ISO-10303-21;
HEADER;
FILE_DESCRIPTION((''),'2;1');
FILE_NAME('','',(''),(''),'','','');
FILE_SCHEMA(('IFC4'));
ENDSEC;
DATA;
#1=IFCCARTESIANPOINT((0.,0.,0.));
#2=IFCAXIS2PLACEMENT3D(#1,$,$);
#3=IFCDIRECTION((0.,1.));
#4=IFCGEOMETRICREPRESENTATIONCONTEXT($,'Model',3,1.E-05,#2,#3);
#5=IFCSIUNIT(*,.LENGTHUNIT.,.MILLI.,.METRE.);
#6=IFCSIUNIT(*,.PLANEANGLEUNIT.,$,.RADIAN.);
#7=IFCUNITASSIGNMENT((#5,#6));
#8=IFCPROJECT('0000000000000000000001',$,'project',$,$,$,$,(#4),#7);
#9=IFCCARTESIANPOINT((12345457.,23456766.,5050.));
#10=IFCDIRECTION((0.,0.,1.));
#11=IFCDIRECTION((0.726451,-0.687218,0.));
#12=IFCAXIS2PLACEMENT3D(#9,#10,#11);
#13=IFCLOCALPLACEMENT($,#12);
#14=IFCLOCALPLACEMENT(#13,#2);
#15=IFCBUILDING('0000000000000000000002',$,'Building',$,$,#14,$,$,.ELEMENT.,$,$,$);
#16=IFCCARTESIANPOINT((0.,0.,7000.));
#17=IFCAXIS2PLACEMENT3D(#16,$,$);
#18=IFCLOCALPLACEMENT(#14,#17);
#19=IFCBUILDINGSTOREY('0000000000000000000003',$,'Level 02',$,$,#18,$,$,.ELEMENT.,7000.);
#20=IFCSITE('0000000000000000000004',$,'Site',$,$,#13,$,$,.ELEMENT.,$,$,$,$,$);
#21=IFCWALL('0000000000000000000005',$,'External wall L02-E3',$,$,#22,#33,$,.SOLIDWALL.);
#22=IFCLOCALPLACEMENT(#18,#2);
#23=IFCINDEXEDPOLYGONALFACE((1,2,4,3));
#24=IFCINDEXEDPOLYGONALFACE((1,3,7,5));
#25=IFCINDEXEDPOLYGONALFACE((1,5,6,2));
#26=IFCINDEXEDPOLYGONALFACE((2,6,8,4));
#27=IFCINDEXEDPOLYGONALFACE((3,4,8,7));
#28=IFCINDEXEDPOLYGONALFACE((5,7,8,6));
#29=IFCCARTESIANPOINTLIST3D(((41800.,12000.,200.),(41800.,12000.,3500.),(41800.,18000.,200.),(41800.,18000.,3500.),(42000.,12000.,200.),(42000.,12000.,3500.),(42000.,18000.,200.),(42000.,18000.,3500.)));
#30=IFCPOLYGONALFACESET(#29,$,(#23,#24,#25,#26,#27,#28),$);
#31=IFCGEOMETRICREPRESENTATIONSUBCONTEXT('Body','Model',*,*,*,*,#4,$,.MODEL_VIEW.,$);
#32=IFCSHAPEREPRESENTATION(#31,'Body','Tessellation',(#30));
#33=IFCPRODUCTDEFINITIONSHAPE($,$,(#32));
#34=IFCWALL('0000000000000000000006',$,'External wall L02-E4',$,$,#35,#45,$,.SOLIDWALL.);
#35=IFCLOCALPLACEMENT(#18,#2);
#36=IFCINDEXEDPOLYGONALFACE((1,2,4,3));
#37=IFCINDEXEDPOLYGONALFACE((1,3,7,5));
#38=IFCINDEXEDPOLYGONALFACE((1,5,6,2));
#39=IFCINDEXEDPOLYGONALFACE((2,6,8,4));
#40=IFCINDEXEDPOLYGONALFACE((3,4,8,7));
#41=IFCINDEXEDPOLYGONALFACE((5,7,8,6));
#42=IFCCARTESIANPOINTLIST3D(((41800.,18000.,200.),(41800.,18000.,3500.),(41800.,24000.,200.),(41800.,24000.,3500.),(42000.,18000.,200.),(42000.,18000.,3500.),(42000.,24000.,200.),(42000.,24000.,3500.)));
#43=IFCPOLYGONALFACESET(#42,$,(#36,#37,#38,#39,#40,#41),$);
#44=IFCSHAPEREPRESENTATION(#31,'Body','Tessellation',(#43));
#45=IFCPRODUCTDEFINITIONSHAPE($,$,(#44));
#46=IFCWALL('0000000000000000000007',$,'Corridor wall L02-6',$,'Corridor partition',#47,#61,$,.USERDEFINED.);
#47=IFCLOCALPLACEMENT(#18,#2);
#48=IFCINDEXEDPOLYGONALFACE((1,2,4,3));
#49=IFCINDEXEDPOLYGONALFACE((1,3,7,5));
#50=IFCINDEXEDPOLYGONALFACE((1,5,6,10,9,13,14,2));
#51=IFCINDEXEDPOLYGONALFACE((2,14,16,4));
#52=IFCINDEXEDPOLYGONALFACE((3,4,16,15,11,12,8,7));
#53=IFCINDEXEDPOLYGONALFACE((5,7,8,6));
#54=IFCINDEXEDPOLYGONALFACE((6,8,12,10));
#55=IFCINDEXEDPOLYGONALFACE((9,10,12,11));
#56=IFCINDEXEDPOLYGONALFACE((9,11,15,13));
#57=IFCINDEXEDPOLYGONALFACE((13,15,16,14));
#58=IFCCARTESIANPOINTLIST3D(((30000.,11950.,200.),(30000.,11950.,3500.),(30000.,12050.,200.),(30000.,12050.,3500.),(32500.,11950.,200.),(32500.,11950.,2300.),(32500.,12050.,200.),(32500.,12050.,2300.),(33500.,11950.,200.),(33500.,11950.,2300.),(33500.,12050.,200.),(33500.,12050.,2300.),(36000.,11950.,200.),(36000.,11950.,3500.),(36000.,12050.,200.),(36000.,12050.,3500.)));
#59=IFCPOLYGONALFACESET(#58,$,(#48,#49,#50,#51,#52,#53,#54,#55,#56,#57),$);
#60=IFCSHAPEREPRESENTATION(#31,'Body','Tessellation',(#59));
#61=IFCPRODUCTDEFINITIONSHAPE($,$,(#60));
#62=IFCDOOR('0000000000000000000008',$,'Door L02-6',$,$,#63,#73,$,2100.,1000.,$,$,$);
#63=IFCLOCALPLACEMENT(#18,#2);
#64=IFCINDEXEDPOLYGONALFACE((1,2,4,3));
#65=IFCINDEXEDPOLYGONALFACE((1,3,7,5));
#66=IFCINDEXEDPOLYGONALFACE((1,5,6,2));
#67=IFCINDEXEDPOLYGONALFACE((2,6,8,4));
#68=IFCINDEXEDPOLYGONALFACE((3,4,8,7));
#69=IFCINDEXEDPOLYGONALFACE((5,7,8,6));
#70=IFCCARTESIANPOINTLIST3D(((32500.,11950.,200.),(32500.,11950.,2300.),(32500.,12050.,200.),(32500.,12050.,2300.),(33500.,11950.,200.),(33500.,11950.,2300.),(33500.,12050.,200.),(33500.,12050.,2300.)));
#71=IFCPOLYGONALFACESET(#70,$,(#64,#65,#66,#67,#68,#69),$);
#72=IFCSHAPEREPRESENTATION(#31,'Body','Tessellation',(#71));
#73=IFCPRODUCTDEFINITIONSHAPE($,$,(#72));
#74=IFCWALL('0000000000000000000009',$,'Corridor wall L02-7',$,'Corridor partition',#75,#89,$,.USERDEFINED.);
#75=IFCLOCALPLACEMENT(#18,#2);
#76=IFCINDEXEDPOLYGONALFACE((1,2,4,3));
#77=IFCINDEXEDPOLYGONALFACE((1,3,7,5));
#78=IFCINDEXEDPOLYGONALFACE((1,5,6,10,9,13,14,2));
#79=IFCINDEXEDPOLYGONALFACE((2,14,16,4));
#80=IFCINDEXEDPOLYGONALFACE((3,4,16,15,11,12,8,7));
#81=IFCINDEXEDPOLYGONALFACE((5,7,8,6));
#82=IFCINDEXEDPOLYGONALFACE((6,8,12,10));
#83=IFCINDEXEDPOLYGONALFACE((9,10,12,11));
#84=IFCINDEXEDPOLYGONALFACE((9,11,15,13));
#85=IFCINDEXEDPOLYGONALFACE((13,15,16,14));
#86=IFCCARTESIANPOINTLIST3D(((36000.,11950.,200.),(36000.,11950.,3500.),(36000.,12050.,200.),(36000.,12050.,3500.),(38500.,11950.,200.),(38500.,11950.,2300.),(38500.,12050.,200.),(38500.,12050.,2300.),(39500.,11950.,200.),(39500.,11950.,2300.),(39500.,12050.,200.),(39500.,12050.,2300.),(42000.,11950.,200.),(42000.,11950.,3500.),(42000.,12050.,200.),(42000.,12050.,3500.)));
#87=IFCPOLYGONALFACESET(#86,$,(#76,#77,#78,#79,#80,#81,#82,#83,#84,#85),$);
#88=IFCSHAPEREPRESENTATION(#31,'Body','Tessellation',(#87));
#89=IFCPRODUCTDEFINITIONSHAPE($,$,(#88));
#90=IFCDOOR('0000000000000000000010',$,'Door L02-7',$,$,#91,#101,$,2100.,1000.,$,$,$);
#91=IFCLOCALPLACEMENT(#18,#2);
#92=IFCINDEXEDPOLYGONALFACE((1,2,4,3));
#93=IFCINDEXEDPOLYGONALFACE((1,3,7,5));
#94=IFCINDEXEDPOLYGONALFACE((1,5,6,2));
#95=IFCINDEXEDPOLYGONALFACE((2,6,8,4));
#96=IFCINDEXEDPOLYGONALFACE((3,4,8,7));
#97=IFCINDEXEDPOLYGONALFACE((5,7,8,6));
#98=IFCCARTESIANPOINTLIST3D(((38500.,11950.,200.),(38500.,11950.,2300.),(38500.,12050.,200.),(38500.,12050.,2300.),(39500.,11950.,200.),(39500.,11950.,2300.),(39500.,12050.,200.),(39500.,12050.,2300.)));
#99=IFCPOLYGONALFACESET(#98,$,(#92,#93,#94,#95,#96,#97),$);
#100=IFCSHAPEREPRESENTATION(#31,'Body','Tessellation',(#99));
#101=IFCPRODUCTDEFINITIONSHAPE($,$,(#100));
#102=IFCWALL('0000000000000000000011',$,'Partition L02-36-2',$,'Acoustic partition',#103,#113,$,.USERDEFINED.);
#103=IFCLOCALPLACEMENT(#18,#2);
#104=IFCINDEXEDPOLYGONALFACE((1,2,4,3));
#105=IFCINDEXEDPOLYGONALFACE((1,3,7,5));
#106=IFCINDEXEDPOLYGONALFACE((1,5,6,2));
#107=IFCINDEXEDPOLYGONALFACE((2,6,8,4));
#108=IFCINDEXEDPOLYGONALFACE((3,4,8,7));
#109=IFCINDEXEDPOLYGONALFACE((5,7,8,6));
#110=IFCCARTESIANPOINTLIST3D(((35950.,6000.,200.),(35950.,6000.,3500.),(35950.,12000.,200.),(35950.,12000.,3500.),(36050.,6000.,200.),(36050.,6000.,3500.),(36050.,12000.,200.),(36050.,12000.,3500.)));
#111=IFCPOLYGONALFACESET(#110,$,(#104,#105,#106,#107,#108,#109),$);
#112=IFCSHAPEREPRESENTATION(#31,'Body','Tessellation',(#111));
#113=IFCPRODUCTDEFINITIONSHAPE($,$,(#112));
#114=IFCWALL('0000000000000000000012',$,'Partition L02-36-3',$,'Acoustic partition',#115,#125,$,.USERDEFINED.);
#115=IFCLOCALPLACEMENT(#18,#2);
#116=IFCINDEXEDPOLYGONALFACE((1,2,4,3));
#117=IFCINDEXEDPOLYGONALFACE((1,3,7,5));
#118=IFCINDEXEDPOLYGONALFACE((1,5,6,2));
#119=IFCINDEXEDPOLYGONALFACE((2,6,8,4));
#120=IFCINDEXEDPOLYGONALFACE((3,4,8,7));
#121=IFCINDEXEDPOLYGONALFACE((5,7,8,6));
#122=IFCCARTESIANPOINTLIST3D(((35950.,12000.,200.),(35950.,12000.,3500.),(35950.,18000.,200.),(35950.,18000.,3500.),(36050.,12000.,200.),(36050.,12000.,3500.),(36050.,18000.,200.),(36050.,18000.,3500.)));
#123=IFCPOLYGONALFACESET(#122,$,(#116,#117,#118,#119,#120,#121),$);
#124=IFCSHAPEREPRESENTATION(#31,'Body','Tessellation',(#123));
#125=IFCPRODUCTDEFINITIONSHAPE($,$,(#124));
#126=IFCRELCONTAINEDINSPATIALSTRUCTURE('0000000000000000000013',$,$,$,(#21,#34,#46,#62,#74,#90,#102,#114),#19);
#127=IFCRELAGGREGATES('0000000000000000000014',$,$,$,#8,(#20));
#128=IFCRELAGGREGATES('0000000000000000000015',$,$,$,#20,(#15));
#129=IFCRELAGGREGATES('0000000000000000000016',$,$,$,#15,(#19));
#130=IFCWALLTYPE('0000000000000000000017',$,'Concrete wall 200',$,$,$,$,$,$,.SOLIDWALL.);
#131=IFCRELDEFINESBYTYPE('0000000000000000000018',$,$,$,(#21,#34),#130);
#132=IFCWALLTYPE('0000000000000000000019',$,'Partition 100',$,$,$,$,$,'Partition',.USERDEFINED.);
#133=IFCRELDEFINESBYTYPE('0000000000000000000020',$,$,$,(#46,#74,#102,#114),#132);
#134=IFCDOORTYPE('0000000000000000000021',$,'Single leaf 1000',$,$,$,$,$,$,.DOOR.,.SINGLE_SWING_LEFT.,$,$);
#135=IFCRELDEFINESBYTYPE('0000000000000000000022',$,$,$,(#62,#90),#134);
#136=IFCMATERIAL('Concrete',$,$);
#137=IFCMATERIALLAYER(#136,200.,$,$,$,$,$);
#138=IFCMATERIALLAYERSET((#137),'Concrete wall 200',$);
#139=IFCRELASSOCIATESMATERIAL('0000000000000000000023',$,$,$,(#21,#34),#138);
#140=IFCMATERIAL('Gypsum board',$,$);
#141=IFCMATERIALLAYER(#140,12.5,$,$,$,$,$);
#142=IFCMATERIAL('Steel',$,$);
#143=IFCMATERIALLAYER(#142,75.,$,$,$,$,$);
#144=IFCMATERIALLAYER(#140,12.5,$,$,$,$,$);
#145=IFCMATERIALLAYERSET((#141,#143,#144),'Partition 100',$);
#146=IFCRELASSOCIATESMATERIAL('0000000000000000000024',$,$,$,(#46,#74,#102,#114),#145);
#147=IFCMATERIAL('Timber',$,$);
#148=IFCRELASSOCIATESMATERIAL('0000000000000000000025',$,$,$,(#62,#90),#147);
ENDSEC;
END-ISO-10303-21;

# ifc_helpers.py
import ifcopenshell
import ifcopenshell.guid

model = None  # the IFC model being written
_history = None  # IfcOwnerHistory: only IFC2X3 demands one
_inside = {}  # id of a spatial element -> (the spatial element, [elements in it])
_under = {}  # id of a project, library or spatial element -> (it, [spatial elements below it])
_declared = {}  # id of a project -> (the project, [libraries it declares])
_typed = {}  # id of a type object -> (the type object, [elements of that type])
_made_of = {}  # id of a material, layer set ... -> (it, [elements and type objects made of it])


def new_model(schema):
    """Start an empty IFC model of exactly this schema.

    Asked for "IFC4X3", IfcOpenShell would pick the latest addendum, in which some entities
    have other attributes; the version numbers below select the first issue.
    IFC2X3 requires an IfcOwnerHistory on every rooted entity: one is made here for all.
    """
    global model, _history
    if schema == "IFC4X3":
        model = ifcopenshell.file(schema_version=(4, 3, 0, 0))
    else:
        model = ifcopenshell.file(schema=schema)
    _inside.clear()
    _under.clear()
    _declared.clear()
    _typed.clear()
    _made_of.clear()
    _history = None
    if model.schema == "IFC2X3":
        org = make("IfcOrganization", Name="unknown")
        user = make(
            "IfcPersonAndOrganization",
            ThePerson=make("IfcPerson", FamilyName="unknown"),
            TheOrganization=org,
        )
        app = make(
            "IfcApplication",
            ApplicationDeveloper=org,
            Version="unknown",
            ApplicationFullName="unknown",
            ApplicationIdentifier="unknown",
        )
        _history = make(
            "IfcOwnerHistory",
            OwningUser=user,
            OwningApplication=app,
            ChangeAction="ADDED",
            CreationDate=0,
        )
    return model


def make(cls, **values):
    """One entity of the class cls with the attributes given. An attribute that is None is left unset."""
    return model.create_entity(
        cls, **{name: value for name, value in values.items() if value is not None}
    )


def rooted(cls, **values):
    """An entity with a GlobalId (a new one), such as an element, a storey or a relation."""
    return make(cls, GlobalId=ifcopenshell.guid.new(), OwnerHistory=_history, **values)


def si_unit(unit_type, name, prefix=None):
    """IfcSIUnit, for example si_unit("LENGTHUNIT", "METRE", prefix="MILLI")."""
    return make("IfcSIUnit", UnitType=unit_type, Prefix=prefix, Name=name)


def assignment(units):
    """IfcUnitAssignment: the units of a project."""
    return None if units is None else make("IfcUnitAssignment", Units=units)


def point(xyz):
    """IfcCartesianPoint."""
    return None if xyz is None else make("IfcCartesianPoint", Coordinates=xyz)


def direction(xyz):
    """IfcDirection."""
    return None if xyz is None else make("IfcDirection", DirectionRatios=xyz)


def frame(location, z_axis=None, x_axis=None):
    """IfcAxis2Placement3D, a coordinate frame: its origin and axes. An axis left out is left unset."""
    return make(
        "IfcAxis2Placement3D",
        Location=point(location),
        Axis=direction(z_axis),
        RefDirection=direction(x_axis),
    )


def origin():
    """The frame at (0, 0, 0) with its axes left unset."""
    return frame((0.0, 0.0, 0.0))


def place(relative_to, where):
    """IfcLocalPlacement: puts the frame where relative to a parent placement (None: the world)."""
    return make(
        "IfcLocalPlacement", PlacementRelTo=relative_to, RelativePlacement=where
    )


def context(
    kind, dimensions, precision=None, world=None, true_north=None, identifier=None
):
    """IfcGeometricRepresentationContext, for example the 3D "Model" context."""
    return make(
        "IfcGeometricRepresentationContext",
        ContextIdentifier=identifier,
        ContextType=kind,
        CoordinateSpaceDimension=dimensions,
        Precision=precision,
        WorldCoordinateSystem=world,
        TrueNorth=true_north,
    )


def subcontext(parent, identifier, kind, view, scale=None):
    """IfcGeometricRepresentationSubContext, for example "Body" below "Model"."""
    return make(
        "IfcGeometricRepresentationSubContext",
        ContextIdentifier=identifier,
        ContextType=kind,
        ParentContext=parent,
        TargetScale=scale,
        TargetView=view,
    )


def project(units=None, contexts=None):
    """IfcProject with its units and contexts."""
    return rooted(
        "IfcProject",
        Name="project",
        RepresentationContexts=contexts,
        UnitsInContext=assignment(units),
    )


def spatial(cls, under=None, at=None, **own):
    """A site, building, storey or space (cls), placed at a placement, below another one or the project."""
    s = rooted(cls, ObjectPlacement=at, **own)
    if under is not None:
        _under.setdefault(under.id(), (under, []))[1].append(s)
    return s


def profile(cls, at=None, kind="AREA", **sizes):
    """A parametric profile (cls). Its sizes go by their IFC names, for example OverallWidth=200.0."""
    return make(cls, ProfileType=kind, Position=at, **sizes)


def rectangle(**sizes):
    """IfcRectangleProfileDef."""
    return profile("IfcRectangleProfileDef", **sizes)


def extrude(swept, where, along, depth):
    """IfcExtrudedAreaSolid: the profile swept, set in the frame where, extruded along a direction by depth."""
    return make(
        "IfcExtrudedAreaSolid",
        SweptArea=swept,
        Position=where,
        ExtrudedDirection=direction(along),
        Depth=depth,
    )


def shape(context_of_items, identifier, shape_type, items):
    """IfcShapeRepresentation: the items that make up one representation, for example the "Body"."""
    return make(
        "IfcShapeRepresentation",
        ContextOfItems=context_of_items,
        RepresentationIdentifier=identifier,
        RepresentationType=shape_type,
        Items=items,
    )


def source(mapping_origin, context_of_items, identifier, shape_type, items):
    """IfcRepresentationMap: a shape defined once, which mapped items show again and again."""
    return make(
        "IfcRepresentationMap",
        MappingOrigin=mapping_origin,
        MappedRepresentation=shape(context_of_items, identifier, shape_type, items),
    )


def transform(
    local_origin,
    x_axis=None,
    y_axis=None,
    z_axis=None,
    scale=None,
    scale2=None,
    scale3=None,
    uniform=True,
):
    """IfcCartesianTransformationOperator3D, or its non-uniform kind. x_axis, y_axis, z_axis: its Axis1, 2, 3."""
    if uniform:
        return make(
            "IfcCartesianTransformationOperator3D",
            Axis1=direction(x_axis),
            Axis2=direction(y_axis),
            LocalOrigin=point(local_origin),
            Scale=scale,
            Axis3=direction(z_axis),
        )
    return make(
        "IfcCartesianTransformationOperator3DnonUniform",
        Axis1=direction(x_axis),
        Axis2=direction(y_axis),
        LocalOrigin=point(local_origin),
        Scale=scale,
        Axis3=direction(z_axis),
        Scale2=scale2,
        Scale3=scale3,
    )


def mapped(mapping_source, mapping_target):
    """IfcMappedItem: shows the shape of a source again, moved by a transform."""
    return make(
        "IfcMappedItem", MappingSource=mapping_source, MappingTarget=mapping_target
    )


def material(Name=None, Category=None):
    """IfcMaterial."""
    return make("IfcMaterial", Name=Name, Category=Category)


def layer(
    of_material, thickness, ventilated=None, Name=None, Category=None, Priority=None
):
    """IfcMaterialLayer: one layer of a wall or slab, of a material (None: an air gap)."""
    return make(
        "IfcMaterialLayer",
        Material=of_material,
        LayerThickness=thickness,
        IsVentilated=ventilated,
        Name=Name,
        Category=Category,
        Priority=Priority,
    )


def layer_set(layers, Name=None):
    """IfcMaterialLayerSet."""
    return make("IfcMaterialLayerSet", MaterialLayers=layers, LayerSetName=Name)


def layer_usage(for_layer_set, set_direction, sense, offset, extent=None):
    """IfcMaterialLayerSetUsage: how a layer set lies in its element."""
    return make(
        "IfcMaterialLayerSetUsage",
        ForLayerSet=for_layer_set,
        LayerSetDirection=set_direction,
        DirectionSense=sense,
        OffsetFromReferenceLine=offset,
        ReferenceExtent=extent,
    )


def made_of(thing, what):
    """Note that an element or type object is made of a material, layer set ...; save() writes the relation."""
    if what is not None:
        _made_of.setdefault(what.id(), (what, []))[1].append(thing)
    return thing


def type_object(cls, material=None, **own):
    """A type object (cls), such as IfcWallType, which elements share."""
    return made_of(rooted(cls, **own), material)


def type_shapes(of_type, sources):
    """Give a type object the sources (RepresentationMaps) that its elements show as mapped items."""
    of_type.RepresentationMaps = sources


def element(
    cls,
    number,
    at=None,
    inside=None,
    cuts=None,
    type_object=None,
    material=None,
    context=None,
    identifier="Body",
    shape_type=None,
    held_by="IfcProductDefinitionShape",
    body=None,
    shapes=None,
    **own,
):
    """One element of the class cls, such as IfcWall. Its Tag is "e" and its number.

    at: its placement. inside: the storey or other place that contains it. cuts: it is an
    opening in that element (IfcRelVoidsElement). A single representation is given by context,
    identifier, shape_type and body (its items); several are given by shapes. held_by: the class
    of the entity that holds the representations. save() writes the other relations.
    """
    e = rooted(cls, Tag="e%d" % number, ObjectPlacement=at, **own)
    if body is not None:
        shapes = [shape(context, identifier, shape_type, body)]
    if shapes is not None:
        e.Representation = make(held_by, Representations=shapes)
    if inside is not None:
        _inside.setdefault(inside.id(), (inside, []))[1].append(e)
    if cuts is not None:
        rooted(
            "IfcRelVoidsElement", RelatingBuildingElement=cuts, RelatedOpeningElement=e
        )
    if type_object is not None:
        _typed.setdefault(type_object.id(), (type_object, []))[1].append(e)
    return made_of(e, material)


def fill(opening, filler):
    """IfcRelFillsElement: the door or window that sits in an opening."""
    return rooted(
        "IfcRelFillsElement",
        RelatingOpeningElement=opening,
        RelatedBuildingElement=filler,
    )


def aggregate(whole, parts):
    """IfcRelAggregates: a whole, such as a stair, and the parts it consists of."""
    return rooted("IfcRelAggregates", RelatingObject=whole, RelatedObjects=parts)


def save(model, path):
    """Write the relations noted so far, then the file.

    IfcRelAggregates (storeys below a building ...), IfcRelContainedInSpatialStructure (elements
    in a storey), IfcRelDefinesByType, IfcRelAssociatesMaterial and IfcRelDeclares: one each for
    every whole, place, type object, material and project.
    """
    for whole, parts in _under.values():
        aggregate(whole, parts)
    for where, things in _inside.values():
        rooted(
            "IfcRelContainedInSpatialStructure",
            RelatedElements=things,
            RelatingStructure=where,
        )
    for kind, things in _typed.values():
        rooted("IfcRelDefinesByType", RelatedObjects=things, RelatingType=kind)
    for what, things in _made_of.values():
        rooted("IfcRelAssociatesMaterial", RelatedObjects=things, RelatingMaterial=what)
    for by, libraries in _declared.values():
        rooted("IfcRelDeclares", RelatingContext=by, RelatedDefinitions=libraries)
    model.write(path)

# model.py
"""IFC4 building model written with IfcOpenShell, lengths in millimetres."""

from ifc_helpers import new_model, si_unit, direction, frame, origin, place, context, subcontext, project, spatial, rectangle, extrude, source, transform, mapped, material, layer, layer_set, layer_usage, type_object, type_shapes, element, fill, save


model = new_model("IFC4")

# Units and contexts
model_context = context("Model", 3, precision=1e-05, world=origin(), true_north=direction((0.0, 1.0)))
body_context = subcontext(model_context, "Body", "Model", "MODEL_VIEW")
ifc_project = project(units=[si_unit("LENGTHUNIT", "METRE", prefix="MILLI"), si_unit("PLANEANGLEUNIT", "RADIAN")], contexts=[model_context])

# Site, building, storey
site_placement = place(None, frame((12345457.0, 23456766.0, 5050.0), z_axis=(0.0, 0.0, 1.0), x_axis=(0.726451, -0.687218, 0.0)))
site = spatial("IfcSite", under=ifc_project, at=site_placement, Name="Site", CompositionType="ELEMENT")
building_placement = place(site_placement, origin())
building = spatial("IfcBuilding", under=site, at=building_placement, Name="Building", CompositionType="ELEMENT")
storey_placement = place(building_placement, frame((0.0, 0.0, 7000.0)))
storey = spatial("IfcBuildingStorey", under=building, at=storey_placement, Name="Level 02", CompositionType="ELEMENT", Elevation=7000.0)

# Shared definitions
ifc_material_1 = material(Name="Steel")

# Shared definitions
ifc_material_2 = material(Name="Concrete")

# Walls
ifc_layer_1 = layer(ifc_material_2, 200.0)
ifc_layer_set_1 = layer_set([ifc_layer_1], Name="Concrete wall 200")
ifc_layer_usage_1 = layer_usage(ifc_layer_set_1, "AXIS2", "POSITIVE", 0.0)
wall_type_1 = type_object("IfcWallType", Name="Concrete wall 200", PredefinedType="SOLIDWALL")
for number, where, name in (
    (1, (41800.0, 12000.0, 200.0), "External wall L02-E3"),
    (2, (41800.0, 18000.0, 200.0), "External wall L02-E4"),
):
    element("IfcWall", number, at=place(storey_placement, frame(where)), inside=storey, type_object=wall_type_1, material=ifc_layer_usage_1, Name=name, PredefinedType="SOLIDWALL", context=body_context, shape_type="SweptSolid", body=[
        extrude(rectangle(XDim=200.0, YDim=6000.0), frame((100.0, 3000.0, 0.0)), (0.0, 0.0, 1.0), 3300.0),
    ])

# Walls, openings, doors
ifc_material_3 = material(Name="Gypsum board")
ifc_layer_2 = layer(ifc_material_3, 12.5)
ifc_layer_3 = layer(ifc_material_1, 75.0)
ifc_layer_4 = layer(ifc_material_3, 12.5)
ifc_layer_set_2 = layer_set([ifc_layer_2, ifc_layer_3, ifc_layer_4], Name="Partition 100")
ifc_layer_usage_2 = layer_usage(ifc_layer_set_2, "AXIS2", "POSITIVE", 0.0)
wall_type_2 = type_object("IfcWallType", Name="Partition 100", ElementType="Partition", PredefinedType="USERDEFINED")
wall_1_placement = place(storey_placement, frame((30000.0, 11950.0, 200.0)))
wall_1 = element("IfcWall", 3, at=wall_1_placement, inside=storey, type_object=wall_type_2, material=ifc_layer_usage_2, Name="Corridor wall L02-6", ObjectType="Corridor partition", PredefinedType="USERDEFINED", context=body_context, shape_type="SweptSolid", body=[
    extrude(rectangle(XDim=6000.0, YDim=100.0), frame((3000.0, 50.0, 0.0)), (0.0, 0.0, 1.0), 3300.0),
])
opening_1_placement = place(wall_1_placement, frame((2500.0, -50.0, 0.0)))
opening_1 = element("IfcOpeningElement", 4, at=opening_1_placement, cuts=wall_1, PredefinedType="OPENING", context=body_context, shape_type="SweptSolid", body=[
    extrude(rectangle(XDim=1000.0, YDim=200.0), frame((500.0, 100.0, 0.0)), (0.0, 0.0, 1.0), 2100.0),
])
ifc_material_4 = material(Name="Timber")
door_type = type_object("IfcDoorType", Name="Single leaf 1000", OperationType="SINGLE_SWING_LEFT", PredefinedType="DOOR")
shared_shape = source(origin(), body_context, "Body", "SweptSolid", [
    extrude(rectangle(XDim=1000.0, YDim=100.0), frame((500.0, 50.0, 0.0)), (0.0, 0.0, 1.0), 2100.0),
])
type_shapes(door_type, [shared_shape])
door_1_placement = place(storey_placement, frame((32500.0, 11950.0, 200.0)))
door_1 = element("IfcDoor", 5, at=door_1_placement, inside=storey, type_object=door_type, material=ifc_material_4, Name="Door L02-6", OverallHeight=2100.0, OverallWidth=1000.0, context=body_context, shape_type="MappedRepresentation", body=[
    mapped(shared_shape, transform((0.0, 0.0, 0.0))),
])
fill(opening_1, door_1)
wall_2_placement = place(storey_placement, frame((36000.0, 11950.0, 200.0)))
wall_2 = element("IfcWall", 6, at=wall_2_placement, inside=storey, type_object=wall_type_2, material=ifc_layer_usage_2, Name="Corridor wall L02-7", ObjectType="Corridor partition", PredefinedType="USERDEFINED", context=body_context, shape_type="SweptSolid", body=[
    extrude(rectangle(XDim=6000.0, YDim=100.0), frame((3000.0, 50.0, 0.0)), (0.0, 0.0, 1.0), 3300.0),
])
opening_2_placement = place(wall_2_placement, frame((2500.0, -50.0, 0.0)))
opening_2 = element("IfcOpeningElement", 7, at=opening_2_placement, cuts=wall_2, PredefinedType="OPENING", context=body_context, shape_type="SweptSolid", body=[
    extrude(rectangle(XDim=1000.0, YDim=200.0), frame((500.0, 100.0, 0.0)), (0.0, 0.0, 1.0), 2100.0),
])
door_2_placement = place(storey_placement, frame((38500.0, 11950.0, 200.0)))
door_2 = element("IfcDoor", 8, at=door_2_placement, inside=storey, type_object=door_type, material=ifc_material_4, Name="Door L02-7", OverallHeight=2100.0, OverallWidth=1000.0, context=body_context, shape_type="MappedRepresentation", body=[
    mapped(shared_shape, transform((0.0, 0.0, 0.0))),
])
fill(opening_2, door_2)

# Walls
for number, where, name in (
    (9, (35950.0, 6000.0, 200.0), "Partition L02-36-2"),
    (10, (35950.0, 12000.0, 200.0), "Partition L02-36-3"),
):
    element("IfcWall", number, at=place(storey_placement, frame(where)), inside=storey, type_object=wall_type_2, material=ifc_layer_usage_2, Name=name, ObjectType="Acoustic partition", PredefinedType="USERDEFINED", context=body_context, shape_type="SweptSolid", body=[
        extrude(rectangle(XDim=100.0, YDim=6000.0), frame((50.0, 3000.0, 0.0)), (0.0, 0.0, 1.0), 3300.0),
    ])

save(model, "model.ifc")
